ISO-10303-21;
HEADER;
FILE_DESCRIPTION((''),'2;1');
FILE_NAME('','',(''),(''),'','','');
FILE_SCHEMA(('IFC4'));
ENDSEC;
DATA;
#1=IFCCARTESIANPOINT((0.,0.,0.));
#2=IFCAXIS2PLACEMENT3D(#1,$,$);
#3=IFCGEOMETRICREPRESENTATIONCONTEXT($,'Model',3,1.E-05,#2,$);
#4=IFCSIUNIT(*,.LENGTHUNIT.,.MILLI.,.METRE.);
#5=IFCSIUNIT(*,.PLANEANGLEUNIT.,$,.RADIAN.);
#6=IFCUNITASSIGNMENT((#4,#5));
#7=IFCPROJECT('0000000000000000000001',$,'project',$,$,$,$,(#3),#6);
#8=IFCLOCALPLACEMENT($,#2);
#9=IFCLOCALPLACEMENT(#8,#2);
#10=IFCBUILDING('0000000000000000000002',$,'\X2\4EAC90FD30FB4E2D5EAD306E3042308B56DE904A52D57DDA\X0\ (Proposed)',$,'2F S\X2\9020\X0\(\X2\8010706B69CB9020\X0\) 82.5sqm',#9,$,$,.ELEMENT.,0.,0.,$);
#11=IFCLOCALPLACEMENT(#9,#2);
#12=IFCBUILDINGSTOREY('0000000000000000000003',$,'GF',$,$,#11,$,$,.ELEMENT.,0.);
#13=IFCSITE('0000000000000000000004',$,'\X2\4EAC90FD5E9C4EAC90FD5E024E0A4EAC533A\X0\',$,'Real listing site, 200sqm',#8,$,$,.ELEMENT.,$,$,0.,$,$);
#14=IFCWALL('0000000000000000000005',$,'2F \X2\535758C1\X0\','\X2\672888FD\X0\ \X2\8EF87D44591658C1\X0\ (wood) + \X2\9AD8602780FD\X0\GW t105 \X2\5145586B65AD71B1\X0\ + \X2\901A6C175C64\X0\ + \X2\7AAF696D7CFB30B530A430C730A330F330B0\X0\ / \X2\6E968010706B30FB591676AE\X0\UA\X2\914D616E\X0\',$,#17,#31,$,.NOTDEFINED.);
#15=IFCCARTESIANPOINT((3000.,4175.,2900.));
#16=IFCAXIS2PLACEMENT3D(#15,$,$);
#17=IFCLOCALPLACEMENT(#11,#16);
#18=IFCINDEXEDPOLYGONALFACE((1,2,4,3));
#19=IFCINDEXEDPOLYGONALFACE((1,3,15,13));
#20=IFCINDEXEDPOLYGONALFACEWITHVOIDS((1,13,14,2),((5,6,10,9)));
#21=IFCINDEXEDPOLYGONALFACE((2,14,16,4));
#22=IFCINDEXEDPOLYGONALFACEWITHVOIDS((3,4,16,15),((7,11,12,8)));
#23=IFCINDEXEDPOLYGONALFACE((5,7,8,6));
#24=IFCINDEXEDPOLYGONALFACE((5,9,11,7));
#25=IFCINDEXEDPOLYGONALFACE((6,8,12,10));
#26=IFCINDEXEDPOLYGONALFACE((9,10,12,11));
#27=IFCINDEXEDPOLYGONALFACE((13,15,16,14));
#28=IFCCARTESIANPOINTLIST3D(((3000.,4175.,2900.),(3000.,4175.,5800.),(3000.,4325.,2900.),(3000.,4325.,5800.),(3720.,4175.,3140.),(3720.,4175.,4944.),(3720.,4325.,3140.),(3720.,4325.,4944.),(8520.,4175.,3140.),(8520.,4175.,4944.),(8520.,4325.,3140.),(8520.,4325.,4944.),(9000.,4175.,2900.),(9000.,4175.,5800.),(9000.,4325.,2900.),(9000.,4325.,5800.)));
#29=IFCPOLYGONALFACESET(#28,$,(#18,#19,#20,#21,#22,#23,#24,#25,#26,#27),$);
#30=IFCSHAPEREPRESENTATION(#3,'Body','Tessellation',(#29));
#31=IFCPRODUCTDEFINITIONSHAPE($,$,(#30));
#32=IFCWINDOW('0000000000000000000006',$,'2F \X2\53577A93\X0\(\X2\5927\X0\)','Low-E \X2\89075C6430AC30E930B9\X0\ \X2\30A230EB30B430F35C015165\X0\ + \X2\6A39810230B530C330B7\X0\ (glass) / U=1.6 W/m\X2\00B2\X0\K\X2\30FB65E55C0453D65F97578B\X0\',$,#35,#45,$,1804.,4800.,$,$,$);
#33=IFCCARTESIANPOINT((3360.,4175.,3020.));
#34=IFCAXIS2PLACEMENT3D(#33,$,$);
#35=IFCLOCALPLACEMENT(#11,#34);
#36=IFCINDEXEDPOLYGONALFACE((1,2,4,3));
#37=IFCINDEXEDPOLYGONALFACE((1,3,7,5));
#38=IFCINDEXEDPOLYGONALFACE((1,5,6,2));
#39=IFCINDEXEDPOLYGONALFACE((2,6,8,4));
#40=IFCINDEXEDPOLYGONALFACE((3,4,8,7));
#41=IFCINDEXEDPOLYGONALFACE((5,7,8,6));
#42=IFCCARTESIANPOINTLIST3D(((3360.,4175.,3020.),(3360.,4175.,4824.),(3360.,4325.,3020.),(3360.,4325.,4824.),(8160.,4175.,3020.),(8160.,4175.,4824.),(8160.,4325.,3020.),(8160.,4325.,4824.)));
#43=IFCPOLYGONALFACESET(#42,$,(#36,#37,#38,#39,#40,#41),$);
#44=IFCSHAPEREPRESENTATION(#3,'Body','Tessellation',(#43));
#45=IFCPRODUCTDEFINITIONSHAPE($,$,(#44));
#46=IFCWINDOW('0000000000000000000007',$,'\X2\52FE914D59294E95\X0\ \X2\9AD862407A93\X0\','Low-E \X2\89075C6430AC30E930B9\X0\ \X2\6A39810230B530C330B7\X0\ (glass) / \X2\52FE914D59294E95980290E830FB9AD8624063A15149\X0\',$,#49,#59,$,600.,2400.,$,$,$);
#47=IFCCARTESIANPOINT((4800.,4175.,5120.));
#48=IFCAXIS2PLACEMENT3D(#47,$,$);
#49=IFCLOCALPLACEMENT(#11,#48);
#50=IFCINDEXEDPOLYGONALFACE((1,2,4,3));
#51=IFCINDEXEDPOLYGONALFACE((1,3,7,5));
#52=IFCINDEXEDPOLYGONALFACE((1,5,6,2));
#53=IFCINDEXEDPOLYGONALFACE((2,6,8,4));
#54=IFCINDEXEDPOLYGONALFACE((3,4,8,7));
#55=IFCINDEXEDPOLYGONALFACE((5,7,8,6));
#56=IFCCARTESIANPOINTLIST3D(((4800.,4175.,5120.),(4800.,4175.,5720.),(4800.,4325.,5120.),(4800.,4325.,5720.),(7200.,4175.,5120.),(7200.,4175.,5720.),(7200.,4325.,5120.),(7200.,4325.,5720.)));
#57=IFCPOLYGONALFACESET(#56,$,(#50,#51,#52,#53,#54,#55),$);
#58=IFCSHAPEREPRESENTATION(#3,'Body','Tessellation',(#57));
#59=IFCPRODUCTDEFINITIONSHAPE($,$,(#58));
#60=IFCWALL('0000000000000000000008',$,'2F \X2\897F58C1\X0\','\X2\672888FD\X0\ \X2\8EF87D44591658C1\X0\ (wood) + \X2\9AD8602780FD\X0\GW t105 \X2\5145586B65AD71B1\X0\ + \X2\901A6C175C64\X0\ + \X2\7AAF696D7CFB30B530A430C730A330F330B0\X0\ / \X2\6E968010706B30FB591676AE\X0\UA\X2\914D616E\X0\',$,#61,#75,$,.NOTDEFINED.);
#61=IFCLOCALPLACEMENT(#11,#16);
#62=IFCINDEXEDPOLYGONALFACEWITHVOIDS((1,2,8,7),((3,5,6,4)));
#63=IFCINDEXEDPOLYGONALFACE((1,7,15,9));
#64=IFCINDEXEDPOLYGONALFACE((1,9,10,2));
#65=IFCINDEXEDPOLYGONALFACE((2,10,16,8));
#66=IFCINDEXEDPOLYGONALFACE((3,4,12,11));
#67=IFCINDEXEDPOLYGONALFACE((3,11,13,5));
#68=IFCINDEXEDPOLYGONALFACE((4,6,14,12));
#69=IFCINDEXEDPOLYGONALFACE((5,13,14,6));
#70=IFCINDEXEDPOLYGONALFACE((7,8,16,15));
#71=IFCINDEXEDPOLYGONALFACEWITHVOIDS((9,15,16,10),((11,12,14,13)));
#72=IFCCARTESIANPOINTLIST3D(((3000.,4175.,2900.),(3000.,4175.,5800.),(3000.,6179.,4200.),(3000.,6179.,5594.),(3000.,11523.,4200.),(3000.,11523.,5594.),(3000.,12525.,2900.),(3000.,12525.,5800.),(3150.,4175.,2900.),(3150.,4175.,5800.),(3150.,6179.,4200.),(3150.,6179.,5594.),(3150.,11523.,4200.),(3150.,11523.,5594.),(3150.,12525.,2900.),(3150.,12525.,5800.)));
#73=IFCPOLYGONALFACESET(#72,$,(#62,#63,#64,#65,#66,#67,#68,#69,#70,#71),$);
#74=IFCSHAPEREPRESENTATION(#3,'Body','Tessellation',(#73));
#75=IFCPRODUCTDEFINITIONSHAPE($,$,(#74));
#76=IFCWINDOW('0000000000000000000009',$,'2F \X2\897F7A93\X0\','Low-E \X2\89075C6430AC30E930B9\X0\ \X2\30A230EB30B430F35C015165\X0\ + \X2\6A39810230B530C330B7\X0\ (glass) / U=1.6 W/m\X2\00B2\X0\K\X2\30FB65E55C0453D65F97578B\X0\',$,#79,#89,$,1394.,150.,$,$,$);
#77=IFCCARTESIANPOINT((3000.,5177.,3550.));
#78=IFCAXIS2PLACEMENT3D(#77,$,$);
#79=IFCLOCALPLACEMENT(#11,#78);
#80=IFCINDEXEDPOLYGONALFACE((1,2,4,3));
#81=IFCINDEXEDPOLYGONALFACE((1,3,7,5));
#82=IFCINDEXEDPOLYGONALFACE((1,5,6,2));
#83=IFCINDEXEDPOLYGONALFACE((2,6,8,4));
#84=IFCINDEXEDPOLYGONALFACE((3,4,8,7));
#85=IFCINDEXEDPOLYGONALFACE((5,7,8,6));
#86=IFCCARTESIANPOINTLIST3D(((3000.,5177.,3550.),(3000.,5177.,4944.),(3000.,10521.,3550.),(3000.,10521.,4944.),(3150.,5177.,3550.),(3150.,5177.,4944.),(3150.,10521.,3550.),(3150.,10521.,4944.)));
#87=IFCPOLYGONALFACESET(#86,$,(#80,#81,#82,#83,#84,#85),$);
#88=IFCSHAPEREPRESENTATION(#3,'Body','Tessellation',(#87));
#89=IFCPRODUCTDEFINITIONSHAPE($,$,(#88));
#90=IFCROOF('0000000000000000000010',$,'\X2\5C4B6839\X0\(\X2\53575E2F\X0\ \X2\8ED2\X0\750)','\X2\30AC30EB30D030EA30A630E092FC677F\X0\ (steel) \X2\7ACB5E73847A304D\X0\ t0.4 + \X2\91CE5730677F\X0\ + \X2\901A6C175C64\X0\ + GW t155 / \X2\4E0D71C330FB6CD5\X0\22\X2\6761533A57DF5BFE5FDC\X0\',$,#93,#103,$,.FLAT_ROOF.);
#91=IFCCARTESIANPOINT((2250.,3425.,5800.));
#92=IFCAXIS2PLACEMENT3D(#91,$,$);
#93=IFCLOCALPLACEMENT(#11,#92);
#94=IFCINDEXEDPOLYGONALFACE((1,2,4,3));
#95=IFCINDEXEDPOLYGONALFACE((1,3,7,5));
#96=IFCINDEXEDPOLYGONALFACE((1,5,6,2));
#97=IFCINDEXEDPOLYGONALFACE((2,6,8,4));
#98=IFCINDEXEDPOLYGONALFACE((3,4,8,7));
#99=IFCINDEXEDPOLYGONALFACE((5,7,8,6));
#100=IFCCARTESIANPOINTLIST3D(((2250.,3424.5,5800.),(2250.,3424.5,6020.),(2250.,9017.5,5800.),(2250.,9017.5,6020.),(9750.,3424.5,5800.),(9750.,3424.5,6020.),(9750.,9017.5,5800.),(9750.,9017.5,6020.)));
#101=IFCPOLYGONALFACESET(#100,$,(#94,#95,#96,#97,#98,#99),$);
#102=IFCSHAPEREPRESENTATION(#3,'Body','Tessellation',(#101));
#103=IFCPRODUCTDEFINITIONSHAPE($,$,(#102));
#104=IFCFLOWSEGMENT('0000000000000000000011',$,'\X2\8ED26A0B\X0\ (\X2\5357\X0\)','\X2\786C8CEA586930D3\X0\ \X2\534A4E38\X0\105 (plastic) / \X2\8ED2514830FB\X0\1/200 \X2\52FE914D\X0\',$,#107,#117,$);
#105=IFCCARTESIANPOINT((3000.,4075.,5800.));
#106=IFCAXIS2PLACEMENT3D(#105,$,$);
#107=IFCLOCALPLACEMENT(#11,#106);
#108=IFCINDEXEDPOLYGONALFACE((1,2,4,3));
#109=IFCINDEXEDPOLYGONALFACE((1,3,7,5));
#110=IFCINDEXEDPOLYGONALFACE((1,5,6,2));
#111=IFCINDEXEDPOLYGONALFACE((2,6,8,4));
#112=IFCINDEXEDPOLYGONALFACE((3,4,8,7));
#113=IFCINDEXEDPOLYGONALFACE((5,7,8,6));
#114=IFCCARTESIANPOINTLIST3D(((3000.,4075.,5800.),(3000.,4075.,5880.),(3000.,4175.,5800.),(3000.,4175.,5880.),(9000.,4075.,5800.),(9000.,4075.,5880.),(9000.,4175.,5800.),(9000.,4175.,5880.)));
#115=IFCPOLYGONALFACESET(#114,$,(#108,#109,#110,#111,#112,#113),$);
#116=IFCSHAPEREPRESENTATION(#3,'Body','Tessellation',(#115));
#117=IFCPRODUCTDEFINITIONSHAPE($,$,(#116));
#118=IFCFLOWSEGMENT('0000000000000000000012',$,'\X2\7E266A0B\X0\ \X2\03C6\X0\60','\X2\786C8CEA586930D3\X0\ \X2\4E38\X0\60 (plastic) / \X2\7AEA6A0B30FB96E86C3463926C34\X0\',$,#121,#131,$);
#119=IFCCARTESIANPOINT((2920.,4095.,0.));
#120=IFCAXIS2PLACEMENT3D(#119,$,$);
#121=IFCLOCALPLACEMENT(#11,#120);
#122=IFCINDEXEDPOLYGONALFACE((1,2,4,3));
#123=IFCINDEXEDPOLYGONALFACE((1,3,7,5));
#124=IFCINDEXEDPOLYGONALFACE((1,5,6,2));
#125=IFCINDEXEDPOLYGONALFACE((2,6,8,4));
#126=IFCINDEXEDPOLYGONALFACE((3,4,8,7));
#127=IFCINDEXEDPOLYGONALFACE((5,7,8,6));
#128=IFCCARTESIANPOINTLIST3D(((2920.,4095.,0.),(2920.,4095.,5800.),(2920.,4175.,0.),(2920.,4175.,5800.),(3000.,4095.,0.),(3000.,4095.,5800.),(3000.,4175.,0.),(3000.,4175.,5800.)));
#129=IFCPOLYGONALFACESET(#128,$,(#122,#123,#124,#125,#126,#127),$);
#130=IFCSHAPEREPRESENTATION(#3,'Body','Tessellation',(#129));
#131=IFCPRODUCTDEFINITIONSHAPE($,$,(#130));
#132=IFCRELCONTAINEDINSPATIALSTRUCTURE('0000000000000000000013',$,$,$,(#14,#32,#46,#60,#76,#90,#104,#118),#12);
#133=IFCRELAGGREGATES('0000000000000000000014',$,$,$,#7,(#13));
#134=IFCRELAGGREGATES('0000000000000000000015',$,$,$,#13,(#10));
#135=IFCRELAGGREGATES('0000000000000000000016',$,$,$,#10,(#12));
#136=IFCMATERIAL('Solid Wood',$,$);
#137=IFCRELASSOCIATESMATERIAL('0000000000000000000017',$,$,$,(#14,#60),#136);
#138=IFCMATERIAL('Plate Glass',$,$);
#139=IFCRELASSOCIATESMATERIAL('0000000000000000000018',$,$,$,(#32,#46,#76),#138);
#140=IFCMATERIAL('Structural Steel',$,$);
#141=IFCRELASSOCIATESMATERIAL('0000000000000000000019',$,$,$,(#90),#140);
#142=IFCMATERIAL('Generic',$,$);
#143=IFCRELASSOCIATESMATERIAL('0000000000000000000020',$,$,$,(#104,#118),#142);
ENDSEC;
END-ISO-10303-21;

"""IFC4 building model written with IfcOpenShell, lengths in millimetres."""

from ifc_helpers import new_model, si_unit, frame, frame_2d, origin, place, context, project, spatial, rectangle, extrude, material, element, fill, save


model = new_model("IFC4")

# Units and contexts
model_context = context("Model", 3, precision=1e-05, world=origin())
ifc_project = project(units=[si_unit("LENGTHUNIT", "METRE", prefix="MILLI"), si_unit("PLANEANGLEUNIT", "RADIAN")], contexts=[model_context])

# Site, building, storey
site_placement = place(None, origin())
site = spatial("IfcSite", under=ifc_project, at=site_placement, Name="京都府京都市上京区", ObjectType="Real listing site, 200sqm", CompositionType="ELEMENT", RefElevation=0.0)
building_placement = place(site_placement, origin())
building = spatial("IfcBuilding", under=site, at=building_placement, Name="京都・中庭のある回遊動線 (Proposed)", ObjectType="2F S造(耐火構造) 82.5sqm", CompositionType="ELEMENT", ElevationOfRefHeight=0.0, ElevationOfTerrain=0.0)
storey_placement = place(building_placement, origin())
storey = spatial("IfcBuildingStorey", under=building, at=storey_placement, Name="GF", CompositionType="ELEMENT", Elevation=0.0)

# Shared definitions
ifc_material_1 = material(Name="Solid Wood")

# Shared definitions
ifc_material_2 = material(Name="Plate Glass")

# Wall, openings, windows
wall_1_placement = place(storey_placement, frame((3000.0, 4175.0, 2900.0)))
wall_1 = element("IfcWall", 1, at=wall_1_placement, inside=storey, material=ifc_material_1, Name="2F 南壁", Description="木製 軸組外壁 (wood) + 高性能GW t105 充填断熱 + 通気層 + 窯業系サイディング / 準耐火・外皮UA配慮", PredefinedType="NOTDEFINED", context=model_context, shape_type="SweptSolid", body=[
    extrude(rectangle(XDim=6000.0, YDim=150.0, at=frame_2d((3000.0, 75.0))), frame((3000.0, 4175.0, 2900.0)), (0.0, 0.0, 1.0), 2900.0),
])
opening_1_placement = place(storey_placement, frame((3360.0, 4175.0, 3020.0)))
opening_1 = element("IfcOpeningElement", 2, at=opening_1_placement, cuts=wall_1, PredefinedType="NOTDEFINED", context=model_context, shape_type="SweptSolid", body=[
    extrude(rectangle(XDim=4800.0, YDim=150.0, at=frame_2d((2400.0, 75.0))), frame((3360.0, 4175.0, 3020.0)), (0.0, 0.0, 1.0), 1804.0),
])
opening_2_placement = place(storey_placement, frame((4800.0, 4175.0, 5120.0)))
opening_2 = element("IfcOpeningElement", 3, at=opening_2_placement, cuts=wall_1, PredefinedType="NOTDEFINED", context=model_context, shape_type="SweptSolid", body=[
    extrude(rectangle(XDim=2400.0, YDim=150.0, at=frame_2d((1200.0, 75.0))), frame((4800.0, 4175.0, 5120.0)), (0.0, 0.0, 1.0), 600.0),
])
window_1_placement = place(storey_placement, frame((3360.0, 4175.0, 3020.0)))
window_1 = element("IfcWindow", 4, at=window_1_placement, inside=storey, material=ifc_material_2, Name="2F 南窓(大)", Description="Low-E 複層ガラス アルゴン封入 + 樹脂サッシ (glass) / U=1.6 W/m²K・日射取得型", OverallHeight=1804.0, OverallWidth=4800.0, context=model_context, shape_type="SweptSolid", body=[
    extrude(rectangle(XDim=4800.0, YDim=150.0, at=frame_2d((2400.0, 75.0))), frame((3360.0, 4175.0, 3020.0)), (0.0, 0.0, 1.0), 1804.0),
])
fill(opening_1, window_1)
window_2_placement = place(storey_placement, frame((4800.0, 4175.0, 5120.0)))
window_2 = element("IfcWindow", 5, at=window_2_placement, inside=storey, material=ifc_material_2, Name="勾配天井 高所窓", Description="Low-E 複層ガラス 樹脂サッシ (glass) / 勾配天井頂部・高所採光", OverallHeight=600.0, OverallWidth=2400.0, context=model_context, shape_type="SweptSolid", body=[
    extrude(rectangle(XDim=2400.0, YDim=150.0, at=frame_2d((1200.0, 75.0))), frame((4800.0, 4175.0, 5120.0)), (0.0, 0.0, 1.0), 600.0),
])
fill(opening_2, window_2)

# Wall, opening, window
wall_2_placement = place(storey_placement, frame((3000.0, 4175.0, 2900.0)))
wall_2 = element("IfcWall", 6, at=wall_2_placement, inside=storey, material=ifc_material_1, Name="2F 西壁", Description="木製 軸組外壁 (wood) + 高性能GW t105 充填断熱 + 通気層 + 窯業系サイディング / 準耐火・外皮UA配慮", PredefinedType="NOTDEFINED", context=model_context, shape_type="SweptSolid", body=[
    extrude(rectangle(XDim=150.0, YDim=8350.0, at=frame_2d((75.0, 4175.0))), frame((3000.0, 4175.0, 2900.0)), (0.0, 0.0, 1.0), 2900.0),
])
opening_3_placement = place(storey_placement, frame((3000.0, 5177.0, 3550.0)))
opening_3 = element("IfcOpeningElement", 7, at=opening_3_placement, cuts=wall_2, PredefinedType="NOTDEFINED", context=model_context, shape_type="SweptSolid", body=[
    extrude(rectangle(XDim=150.0, YDim=5344.0, at=frame_2d((75.0, 2672.0))), frame((3000.0, 5177.0, 3550.0)), (0.0, 0.0, 1.0), 1394.0),
])
window_3_placement = place(storey_placement, frame((3000.0, 5177.0, 3550.0)))
window_3 = element("IfcWindow", 8, at=window_3_placement, inside=storey, material=ifc_material_2, Name="2F 西窓", Description="Low-E 複層ガラス アルゴン封入 + 樹脂サッシ (glass) / U=1.6 W/m²K・日射取得型", OverallHeight=1394.0, OverallWidth=150.0, context=model_context, shape_type="SweptSolid", body=[
    extrude(rectangle(XDim=150.0, YDim=5344.0, at=frame_2d((75.0, 2672.0))), frame((3000.0, 5177.0, 3550.0)), (0.0, 0.0, 1.0), 1394.0),
])
fill(opening_3, window_3)

# Roof
ifc_material_3 = material(Name="Structural Steel")
for number, where, name in (
    (9, (2250.0, 3425.0, 5800.0), "屋根(南帯 軒750)"),
):
    element("IfcRoof", number, at=place(storey_placement, frame(where)), inside=storey, material=ifc_material_3, Name=name, Description="ガルバリウム鋼板 (steel) 立平葺き t0.4 + 野地板 + 通気層 + GW t155 / 不燃・法22条区域対応", PredefinedType="FLAT_ROOF", context=model_context, shape_type="SweptSolid", body=[
        extrude(rectangle(XDim=7500.0, YDim=5593.0, at=frame_2d((3750.0, 2796.0))), frame((2250.0, 3425.0, 5800.0)), (0.0, 0.0, 1.0), 220.0),
    ])

# Flow segments
ifc_material_4 = material(Name="Generic")
flow_segment_1_placement = place(storey_placement, frame((3000.0, 4075.0, 5800.0)))
element("IfcFlowSegment", 10, at=flow_segment_1_placement, inside=storey, material=ifc_material_4, Name="軒樋 (南)", Description="硬質塩ビ 半丸105 (plastic) / 軒先・1/200 勾配", context=model_context, shape_type="SweptSolid", body=[
    extrude(rectangle(XDim=6000.0, YDim=100.0, at=frame_2d((3000.0, 50.0))), frame((3000.0, 4075.0, 5800.0)), (0.0, 0.0, 1.0), 80.0),
])
flow_segment_2_placement = place(storey_placement, frame((2920.0, 4095.0, 0.0)))
element("IfcFlowSegment", 11, at=flow_segment_2_placement, inside=storey, material=ifc_material_4, Name="縦樋 φ60", Description="硬質塩ビ 丸60 (plastic) / 竪樋・雨水排水", context=model_context, shape_type="SweptSolid", body=[
    extrude(rectangle(XDim=80.0, YDim=80.0, at=frame_2d((40.0, 40.0))), frame((2920.0, 4095.0, 0.0)), (0.0, 0.0, 1.0), 5800.0),
])

save(model, "model.ifc")
